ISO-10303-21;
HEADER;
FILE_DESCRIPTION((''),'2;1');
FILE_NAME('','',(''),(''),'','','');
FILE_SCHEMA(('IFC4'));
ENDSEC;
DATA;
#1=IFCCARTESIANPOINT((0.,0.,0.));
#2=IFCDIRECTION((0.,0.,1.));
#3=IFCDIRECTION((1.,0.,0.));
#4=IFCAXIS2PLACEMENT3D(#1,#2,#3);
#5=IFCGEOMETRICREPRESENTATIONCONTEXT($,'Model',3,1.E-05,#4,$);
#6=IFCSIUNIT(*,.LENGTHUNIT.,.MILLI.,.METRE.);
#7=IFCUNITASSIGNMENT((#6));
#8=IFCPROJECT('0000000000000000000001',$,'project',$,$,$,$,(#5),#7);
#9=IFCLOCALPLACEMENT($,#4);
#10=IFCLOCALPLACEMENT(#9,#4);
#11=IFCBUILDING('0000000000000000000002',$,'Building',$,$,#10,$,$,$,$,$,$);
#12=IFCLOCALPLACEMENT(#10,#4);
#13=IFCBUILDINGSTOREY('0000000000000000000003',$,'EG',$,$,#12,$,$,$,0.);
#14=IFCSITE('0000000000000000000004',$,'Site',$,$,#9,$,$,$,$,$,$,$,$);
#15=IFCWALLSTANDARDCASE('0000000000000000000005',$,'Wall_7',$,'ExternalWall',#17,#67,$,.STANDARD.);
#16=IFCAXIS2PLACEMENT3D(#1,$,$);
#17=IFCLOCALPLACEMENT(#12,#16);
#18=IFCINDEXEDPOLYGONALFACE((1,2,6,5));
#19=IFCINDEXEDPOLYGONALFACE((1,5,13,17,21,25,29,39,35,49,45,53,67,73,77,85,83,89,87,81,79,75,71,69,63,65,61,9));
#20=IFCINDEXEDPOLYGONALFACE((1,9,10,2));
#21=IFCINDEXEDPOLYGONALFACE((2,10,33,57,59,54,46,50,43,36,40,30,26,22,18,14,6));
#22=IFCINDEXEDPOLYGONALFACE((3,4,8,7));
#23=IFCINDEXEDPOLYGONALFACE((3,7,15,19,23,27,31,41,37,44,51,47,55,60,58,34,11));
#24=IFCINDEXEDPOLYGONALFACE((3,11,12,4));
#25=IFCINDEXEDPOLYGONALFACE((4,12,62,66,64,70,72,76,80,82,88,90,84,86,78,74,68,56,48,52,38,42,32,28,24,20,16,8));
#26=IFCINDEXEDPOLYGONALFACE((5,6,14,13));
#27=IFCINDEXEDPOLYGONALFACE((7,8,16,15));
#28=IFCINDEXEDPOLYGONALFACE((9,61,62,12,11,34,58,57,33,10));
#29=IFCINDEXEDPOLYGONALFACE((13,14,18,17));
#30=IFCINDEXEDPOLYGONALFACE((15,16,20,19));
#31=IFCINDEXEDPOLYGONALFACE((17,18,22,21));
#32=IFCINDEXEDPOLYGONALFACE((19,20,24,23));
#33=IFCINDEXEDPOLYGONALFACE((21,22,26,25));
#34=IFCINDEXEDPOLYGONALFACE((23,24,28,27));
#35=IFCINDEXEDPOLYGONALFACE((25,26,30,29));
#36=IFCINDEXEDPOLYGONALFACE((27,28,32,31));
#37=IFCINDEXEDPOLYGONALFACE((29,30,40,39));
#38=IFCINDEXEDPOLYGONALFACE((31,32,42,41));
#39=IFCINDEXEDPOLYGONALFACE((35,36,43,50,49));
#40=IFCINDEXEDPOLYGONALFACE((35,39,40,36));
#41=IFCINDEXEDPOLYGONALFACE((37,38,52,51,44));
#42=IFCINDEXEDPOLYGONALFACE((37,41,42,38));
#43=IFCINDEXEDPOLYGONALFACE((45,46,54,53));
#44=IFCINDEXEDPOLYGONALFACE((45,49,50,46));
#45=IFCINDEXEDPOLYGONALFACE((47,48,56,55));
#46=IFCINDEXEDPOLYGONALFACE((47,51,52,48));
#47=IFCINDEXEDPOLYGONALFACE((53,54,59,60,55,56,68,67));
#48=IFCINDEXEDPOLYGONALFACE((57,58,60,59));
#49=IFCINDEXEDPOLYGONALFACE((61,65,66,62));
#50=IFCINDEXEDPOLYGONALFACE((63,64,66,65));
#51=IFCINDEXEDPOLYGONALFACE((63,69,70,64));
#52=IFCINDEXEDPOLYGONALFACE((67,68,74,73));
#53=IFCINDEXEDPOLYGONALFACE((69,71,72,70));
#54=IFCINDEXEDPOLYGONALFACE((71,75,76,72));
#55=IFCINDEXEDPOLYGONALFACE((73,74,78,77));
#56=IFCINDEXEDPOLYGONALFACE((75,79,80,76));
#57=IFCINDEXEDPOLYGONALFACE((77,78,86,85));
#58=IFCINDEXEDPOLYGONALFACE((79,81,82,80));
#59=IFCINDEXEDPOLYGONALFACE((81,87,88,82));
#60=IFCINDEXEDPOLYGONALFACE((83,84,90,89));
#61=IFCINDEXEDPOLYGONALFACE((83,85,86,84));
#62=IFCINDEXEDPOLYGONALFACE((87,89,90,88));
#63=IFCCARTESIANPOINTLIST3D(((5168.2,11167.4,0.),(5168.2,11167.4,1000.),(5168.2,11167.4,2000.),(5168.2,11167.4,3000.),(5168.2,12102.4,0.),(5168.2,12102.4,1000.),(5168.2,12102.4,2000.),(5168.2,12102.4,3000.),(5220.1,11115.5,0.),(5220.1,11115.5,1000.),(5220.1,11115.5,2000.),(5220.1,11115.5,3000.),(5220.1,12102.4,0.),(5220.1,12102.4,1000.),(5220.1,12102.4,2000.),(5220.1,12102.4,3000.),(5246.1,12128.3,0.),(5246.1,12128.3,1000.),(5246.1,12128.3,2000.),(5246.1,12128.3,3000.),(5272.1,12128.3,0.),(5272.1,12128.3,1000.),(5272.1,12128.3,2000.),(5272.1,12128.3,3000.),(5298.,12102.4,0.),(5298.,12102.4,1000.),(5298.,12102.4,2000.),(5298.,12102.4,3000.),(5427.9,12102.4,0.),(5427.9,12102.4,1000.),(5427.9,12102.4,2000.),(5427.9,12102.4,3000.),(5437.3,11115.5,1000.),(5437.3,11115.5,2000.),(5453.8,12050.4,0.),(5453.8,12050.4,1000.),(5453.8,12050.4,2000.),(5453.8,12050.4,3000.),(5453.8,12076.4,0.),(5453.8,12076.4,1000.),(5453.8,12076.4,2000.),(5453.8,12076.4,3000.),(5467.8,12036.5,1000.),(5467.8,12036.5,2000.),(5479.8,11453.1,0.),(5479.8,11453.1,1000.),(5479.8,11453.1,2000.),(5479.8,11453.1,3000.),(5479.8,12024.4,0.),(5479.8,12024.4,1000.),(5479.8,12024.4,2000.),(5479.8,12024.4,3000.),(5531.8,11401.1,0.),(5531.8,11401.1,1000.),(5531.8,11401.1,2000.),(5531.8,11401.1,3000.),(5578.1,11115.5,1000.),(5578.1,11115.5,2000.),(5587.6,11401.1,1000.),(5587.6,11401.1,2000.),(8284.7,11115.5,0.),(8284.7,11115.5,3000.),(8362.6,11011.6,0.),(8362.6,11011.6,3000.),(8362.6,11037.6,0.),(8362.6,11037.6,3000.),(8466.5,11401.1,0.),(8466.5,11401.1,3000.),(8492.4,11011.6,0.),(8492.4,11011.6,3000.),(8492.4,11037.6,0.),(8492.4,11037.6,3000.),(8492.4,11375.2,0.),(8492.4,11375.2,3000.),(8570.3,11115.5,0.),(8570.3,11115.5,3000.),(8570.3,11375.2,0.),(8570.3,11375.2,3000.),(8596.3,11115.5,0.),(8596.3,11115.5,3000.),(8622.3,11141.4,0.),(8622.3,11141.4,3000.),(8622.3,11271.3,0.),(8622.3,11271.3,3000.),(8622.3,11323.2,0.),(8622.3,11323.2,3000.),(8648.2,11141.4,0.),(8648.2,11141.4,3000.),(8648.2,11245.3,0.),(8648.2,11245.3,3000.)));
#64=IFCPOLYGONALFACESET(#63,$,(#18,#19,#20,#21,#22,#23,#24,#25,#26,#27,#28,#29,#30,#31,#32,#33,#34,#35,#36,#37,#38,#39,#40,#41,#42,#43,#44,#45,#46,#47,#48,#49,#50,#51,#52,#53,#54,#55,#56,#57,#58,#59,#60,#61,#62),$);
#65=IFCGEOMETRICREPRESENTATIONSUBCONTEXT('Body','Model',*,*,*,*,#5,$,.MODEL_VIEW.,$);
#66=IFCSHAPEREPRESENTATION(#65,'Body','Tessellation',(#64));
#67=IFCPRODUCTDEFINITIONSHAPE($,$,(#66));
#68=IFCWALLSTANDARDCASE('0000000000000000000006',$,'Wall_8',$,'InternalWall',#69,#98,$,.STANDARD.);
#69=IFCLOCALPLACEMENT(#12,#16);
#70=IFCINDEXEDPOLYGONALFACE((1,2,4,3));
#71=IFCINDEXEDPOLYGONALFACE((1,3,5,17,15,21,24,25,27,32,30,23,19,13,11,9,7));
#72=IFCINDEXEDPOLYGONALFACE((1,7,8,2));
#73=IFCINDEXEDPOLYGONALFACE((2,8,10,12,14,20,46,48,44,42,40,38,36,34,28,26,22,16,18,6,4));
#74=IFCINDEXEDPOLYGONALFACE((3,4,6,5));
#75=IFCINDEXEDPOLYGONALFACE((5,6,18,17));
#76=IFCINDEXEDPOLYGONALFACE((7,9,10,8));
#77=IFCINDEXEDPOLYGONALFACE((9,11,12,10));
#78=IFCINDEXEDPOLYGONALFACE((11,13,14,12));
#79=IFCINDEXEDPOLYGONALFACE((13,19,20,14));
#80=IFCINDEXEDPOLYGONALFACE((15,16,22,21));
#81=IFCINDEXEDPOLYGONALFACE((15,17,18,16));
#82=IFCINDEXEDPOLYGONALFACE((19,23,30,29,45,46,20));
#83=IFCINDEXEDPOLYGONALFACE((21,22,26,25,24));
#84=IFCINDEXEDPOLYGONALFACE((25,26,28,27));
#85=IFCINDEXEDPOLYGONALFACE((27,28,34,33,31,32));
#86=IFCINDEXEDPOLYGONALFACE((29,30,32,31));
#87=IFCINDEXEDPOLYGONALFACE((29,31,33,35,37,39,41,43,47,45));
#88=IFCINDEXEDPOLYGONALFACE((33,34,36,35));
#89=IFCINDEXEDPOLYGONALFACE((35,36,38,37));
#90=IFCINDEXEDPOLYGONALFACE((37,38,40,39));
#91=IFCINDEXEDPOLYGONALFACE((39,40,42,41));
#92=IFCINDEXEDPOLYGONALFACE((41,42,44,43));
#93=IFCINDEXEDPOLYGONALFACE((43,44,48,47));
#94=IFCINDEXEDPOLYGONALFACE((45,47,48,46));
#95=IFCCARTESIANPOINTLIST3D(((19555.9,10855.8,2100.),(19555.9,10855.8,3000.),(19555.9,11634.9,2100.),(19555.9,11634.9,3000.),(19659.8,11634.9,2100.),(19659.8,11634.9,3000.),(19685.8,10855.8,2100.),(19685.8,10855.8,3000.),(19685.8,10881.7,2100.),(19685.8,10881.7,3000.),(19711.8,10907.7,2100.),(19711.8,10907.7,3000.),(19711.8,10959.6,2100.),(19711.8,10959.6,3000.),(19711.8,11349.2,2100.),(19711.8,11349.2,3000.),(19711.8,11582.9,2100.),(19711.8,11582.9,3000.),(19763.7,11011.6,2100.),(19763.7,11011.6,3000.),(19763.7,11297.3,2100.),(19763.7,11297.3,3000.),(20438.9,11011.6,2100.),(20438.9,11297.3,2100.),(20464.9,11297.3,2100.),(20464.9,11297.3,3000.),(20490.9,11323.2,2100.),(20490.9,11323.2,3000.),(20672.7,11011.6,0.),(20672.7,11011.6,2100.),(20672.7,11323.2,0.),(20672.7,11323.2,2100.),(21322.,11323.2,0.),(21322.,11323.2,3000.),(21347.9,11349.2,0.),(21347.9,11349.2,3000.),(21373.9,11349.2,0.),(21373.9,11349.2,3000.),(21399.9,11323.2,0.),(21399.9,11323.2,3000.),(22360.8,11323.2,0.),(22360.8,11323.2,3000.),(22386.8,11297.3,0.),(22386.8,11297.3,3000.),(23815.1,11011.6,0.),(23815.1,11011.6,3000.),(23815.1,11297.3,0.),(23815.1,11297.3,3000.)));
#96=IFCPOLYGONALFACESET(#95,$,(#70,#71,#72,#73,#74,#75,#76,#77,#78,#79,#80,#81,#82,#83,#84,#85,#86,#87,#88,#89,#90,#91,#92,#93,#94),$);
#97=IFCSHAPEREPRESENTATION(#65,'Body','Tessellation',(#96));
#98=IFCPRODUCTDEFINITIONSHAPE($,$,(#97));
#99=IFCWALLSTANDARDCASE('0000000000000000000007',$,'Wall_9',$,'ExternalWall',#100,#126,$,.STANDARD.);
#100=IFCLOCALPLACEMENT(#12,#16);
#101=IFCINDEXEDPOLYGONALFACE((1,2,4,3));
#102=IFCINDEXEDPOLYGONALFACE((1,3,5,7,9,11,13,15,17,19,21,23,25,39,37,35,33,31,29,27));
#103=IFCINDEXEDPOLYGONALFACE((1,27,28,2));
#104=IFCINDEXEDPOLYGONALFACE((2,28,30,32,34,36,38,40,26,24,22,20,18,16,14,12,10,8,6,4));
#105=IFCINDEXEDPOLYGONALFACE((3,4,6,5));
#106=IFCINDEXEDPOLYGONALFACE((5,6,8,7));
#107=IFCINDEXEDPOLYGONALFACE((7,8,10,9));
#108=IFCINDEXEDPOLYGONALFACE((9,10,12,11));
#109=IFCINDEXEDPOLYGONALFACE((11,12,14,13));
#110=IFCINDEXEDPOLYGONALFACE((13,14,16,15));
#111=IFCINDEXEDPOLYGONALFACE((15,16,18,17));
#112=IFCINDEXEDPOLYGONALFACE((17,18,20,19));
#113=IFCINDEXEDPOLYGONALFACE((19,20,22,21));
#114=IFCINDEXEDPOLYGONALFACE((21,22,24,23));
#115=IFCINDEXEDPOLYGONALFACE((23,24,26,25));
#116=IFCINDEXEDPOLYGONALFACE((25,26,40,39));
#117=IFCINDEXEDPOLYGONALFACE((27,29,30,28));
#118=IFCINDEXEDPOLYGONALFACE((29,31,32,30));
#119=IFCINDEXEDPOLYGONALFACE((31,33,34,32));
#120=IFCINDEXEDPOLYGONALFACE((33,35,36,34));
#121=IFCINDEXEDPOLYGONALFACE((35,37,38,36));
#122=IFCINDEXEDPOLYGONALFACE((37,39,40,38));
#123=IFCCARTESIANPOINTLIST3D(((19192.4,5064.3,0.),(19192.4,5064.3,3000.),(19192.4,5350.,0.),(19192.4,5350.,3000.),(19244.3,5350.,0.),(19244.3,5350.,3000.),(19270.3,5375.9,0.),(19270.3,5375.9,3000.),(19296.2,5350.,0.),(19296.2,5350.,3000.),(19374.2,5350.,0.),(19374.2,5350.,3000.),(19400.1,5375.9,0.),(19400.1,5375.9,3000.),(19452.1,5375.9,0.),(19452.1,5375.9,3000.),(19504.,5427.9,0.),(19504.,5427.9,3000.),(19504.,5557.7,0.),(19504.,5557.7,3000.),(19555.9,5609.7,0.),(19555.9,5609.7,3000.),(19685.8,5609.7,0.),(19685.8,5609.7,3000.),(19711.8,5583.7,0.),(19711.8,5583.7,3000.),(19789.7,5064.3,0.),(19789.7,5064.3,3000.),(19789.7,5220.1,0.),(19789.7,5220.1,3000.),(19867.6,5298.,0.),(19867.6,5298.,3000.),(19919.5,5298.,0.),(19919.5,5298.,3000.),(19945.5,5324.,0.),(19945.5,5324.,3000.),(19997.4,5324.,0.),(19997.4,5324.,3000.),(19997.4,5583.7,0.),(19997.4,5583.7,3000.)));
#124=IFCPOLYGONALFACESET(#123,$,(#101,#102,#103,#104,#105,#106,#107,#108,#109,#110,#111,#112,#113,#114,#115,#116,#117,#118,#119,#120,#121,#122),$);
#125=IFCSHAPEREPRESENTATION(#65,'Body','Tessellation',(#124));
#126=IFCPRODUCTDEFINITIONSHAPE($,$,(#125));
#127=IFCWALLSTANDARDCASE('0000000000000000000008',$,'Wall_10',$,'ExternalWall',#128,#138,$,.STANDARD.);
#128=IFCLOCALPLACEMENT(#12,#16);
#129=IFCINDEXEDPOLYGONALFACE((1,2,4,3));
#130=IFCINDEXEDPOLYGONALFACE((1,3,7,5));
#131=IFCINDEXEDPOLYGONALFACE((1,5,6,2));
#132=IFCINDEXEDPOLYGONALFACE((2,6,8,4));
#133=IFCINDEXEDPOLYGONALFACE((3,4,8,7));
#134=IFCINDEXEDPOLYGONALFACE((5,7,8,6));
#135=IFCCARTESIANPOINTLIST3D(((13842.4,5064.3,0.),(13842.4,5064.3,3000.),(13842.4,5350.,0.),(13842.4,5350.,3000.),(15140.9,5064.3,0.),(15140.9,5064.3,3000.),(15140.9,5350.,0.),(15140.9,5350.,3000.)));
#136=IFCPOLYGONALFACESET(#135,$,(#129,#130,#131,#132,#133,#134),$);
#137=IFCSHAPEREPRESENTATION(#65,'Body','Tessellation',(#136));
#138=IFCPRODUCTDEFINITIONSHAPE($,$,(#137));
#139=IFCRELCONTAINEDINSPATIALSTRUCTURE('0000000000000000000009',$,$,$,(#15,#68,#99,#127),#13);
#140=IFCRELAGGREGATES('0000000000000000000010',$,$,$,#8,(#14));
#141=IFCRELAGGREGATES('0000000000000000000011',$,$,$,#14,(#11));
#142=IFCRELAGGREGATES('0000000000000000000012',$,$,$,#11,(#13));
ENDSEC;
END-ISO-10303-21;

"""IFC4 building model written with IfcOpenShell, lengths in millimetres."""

from ifc_helpers import new_model, si_unit, frame, origin_with_axes, place, context, subcontext, project, spatial, polyline, rectangle, outline, extrude, element, save


model = new_model("IFC4")

# Units and contexts
model_context = context("Model", 3, precision=1e-05, world=origin_with_axes())
body_context = subcontext(model_context, "Body", "Model", "MODEL_VIEW")
ifc_project = project(units=[si_unit("LENGTHUNIT", "METRE", prefix="MILLI")], contexts=[model_context])

# Site, building, storey
site_placement = place(None, origin_with_axes())
site = spatial("IfcSite", under=ifc_project, at=site_placement, Name="Site")
building_placement = place(site_placement, origin_with_axes())
building = spatial("IfcBuilding", under=site, at=building_placement, Name="Building")
storey_placement = place(building_placement, origin_with_axes())
storey = spatial("IfcBuildingStorey", under=building, at=storey_placement, Name="EG", Elevation=0.0)

# Walls, openings
wall_1_placement = place(storey_placement, origin_with_axes())
wall_1 = element("IfcWallStandardCase", 1, at=wall_1_placement, inside=storey, Name="Wall_7", ObjectType="ExternalWall", PredefinedType="STANDARD", context=body_context, shape_type="SweptSolid", body=[
    extrude(outline(polyline([(8362.6, 11011.6, 0.0), (8362.6, 11037.6, 0.0), (8284.7, 11115.5, 0.0), (5220.1, 11115.5, 0.0), (5168.2, 11167.4, 0.0), (5168.2, 12102.4, 0.0), (5220.1, 12102.4, 0.0), (5246.1, 12128.3, 0.0), (5272.1, 12128.3, 0.0), (5298.0, 12102.4, 0.0), (5427.9, 12102.4, 0.0), (5453.8, 12076.4, 0.0), (5453.8, 12050.4, 0.0), (5479.8, 12024.4, 0.0), (5479.8, 11453.1, 0.0), (5531.8, 11401.1, 0.0), (8466.5, 11401.1, 0.0), (8492.4, 11375.2, 0.0), (8570.3, 11375.2, 0.0), (8622.3, 11323.2, 0.0), (8622.3, 11271.3, 0.0), (8648.2, 11245.3, 0.0), (8648.2, 11141.4, 0.0), (8622.3, 11141.4, 0.0), (8596.3, 11115.5, 0.0), (8570.3, 11115.5, 0.0), (8492.4, 11037.6, 0.0), (8492.4, 11011.6, 0.0), (8362.6, 11011.6, 0.0)])), origin_with_axes(), (0.0, 0.0, 1.0), 3000.0),
])
opening_1_placement = place(wall_1_placement, origin_with_axes())
element("IfcOpeningElement", 2, at=opening_1_placement, inside=storey, cuts=wall_1, context=body_context, shape_type="SweptSolid", body=[
    extrude(rectangle(XDim=600.0, YDim=1014.0), frame((5294.6, 11620.3, 1000.0), z_axis=(0.0, 0.0, 1.0), x_axis=(0.999454, -0.03304, 0.0)), (0.0, 0.0, 1.0), 1000.0),
])
opening_2_placement = place(wall_1_placement, origin_with_axes())
element("IfcOpeningElement", 3, at=opening_2_placement, inside=storey, cuts=wall_1, context=body_context, shape_type="SweptSolid", body=[
    extrude(rectangle(XDim=600.0, YDim=1014.0), frame((5154.0, 11624.9, 1000.0), z_axis=(0.0, 0.0, 1.0), x_axis=(0.999454, -0.03304, 0.0)), (0.0, 0.0, 1.0), 1000.0),
])
wall_2_placement = place(storey_placement, origin_with_axes())
wall_2 = element("IfcWallStandardCase", 4, at=wall_2_placement, inside=storey, Name="Wall_8", ObjectType="InternalWall", PredefinedType="STANDARD", context=body_context, shape_type="SweptSolid", body=[
    extrude(outline(polyline([(19555.9, 10855.8, 0.0), (19555.9, 11634.9, 0.0), (19659.8, 11634.9, 0.0), (19711.8, 11582.9, 0.0), (19711.8, 11349.2, 0.0), (19763.7, 11297.3, 0.0), (20464.9, 11297.3, 0.0), (20490.9, 11323.2, 0.0), (21322.0, 11323.2, 0.0), (21347.9, 11349.2, 0.0), (21373.9, 11349.2, 0.0), (21399.9, 11323.2, 0.0), (22360.8, 11323.2, 0.0), (22386.8, 11297.3, 0.0), (23815.1, 11297.3, 0.0), (23815.1, 11011.6, 0.0), (19763.7, 11011.6, 0.0), (19711.8, 10959.6, 0.0), (19711.8, 10907.7, 0.0), (19685.8, 10881.7, 0.0), (19685.8, 10855.8, 0.0), (19555.9, 10855.8, 0.0)])), origin_with_axes(), (0.0, 0.0, 1.0), 3000.0),
])
opening_3_placement = place(wall_2_placement, origin_with_axes())
element("IfcOpeningElement", 5, at=opening_3_placement, inside=storey, cuts=wall_2, context=body_context, shape_type="SweptSolid", body=[
    extrude(rectangle(XDim=1116.7, YDim=779.1), frame((20114.3, 11245.3, 0.0), z_axis=(0.0, 0.0, 1.0), x_axis=(1.0, 0.0, 0.0)), (0.0, 0.0, 1.0), 2100.0),
])
opening_4_placement = place(wall_2_placement, origin_with_axes())
element("IfcOpeningElement", 6, at=opening_4_placement, inside=storey, cuts=wall_2, context=body_context, shape_type="SweptSolid", body=[
    extrude(rectangle(XDim=883.0, YDim=779.1), frame((19997.4, 11245.3, 0.0), z_axis=(0.0, 0.0, 1.0), x_axis=(1.0, 0.0, 0.0)), (0.0, 0.0, 1.0), 2100.0),
])
wall_3_placement = place(storey_placement, origin_with_axes())
wall_3 = element("IfcWallStandardCase", 7, at=wall_3_placement, inside=storey, Name="Wall_9", ObjectType="ExternalWall", PredefinedType="STANDARD", context=body_context, shape_type="SweptSolid", body=[
    extrude(outline(polyline([(19192.4, 5064.3, 0.0), (19192.4, 5350.0, 0.0), (19244.3, 5350.0, 0.0), (19270.3, 5375.9, 0.0), (19296.2, 5350.0, 0.0), (19374.2, 5350.0, 0.0), (19400.1, 5375.9, 0.0), (19452.1, 5375.9, 0.0), (19504.0, 5427.9, 0.0), (19504.0, 5557.7, 0.0), (19555.9, 5609.7, 0.0), (19685.8, 5609.7, 0.0), (19711.8, 5583.7, 0.0), (19997.4, 5583.7, 0.0), (19997.4, 5324.0, 0.0), (19945.5, 5324.0, 0.0), (19919.5, 5298.0, 0.0), (19867.6, 5298.0, 0.0), (19789.7, 5220.1, 0.0), (19789.7, 5064.3, 0.0), (19192.4, 5064.3, 0.0)])), origin_with_axes(), (0.0, 0.0, 1.0), 3000.0),
])
opening_5_placement = place(wall_3_placement, origin_with_axes())
element("IfcOpeningElement", 8, at=opening_5_placement, inside=storey, cuts=wall_3, context=body_context, shape_type="SweptSolid", body=[
    extrude(rectangle(XDim=1200.0, YDim=545.4), frame((18530.1, 5193.9, 1000.0), z_axis=(0.0, 0.0, 1.0), x_axis=(1.0, 0.0, 0.0)), (0.0, 0.0, 1.0), 1000.0),
])
opening_6_placement = place(wall_3_placement, origin_with_axes())
element("IfcOpeningElement", 9, at=opening_6_placement, inside=storey, cuts=wall_3, context=body_context, shape_type="SweptSolid", body=[
    extrude(rectangle(XDim=1200.0, YDim=545.4), frame((21763.5, 5492.8, 1000.0), z_axis=(0.0, 0.0, 1.0), x_axis=(1.0, 0.0, 0.0)), (0.0, 0.0, 1.0), 1000.0),
])

# Wall
wall_4_placement = place(storey_placement, origin_with_axes())
element("IfcWallStandardCase", 10, at=wall_4_placement, inside=storey, Name="Wall_10", ObjectType="ExternalWall", PredefinedType="STANDARD", context=body_context, shape_type="SweptSolid", body=[
    extrude(outline(polyline([(13842.4, 5064.3, 0.0), (13842.4, 5350.0, 0.0), (15140.9, 5350.0, 0.0), (15140.9, 5064.3, 0.0), (13842.4, 5064.3, 0.0)])), origin_with_axes(), (0.0, 0.0, 1.0), 3000.0),
])

save(model, "model.ifc")
